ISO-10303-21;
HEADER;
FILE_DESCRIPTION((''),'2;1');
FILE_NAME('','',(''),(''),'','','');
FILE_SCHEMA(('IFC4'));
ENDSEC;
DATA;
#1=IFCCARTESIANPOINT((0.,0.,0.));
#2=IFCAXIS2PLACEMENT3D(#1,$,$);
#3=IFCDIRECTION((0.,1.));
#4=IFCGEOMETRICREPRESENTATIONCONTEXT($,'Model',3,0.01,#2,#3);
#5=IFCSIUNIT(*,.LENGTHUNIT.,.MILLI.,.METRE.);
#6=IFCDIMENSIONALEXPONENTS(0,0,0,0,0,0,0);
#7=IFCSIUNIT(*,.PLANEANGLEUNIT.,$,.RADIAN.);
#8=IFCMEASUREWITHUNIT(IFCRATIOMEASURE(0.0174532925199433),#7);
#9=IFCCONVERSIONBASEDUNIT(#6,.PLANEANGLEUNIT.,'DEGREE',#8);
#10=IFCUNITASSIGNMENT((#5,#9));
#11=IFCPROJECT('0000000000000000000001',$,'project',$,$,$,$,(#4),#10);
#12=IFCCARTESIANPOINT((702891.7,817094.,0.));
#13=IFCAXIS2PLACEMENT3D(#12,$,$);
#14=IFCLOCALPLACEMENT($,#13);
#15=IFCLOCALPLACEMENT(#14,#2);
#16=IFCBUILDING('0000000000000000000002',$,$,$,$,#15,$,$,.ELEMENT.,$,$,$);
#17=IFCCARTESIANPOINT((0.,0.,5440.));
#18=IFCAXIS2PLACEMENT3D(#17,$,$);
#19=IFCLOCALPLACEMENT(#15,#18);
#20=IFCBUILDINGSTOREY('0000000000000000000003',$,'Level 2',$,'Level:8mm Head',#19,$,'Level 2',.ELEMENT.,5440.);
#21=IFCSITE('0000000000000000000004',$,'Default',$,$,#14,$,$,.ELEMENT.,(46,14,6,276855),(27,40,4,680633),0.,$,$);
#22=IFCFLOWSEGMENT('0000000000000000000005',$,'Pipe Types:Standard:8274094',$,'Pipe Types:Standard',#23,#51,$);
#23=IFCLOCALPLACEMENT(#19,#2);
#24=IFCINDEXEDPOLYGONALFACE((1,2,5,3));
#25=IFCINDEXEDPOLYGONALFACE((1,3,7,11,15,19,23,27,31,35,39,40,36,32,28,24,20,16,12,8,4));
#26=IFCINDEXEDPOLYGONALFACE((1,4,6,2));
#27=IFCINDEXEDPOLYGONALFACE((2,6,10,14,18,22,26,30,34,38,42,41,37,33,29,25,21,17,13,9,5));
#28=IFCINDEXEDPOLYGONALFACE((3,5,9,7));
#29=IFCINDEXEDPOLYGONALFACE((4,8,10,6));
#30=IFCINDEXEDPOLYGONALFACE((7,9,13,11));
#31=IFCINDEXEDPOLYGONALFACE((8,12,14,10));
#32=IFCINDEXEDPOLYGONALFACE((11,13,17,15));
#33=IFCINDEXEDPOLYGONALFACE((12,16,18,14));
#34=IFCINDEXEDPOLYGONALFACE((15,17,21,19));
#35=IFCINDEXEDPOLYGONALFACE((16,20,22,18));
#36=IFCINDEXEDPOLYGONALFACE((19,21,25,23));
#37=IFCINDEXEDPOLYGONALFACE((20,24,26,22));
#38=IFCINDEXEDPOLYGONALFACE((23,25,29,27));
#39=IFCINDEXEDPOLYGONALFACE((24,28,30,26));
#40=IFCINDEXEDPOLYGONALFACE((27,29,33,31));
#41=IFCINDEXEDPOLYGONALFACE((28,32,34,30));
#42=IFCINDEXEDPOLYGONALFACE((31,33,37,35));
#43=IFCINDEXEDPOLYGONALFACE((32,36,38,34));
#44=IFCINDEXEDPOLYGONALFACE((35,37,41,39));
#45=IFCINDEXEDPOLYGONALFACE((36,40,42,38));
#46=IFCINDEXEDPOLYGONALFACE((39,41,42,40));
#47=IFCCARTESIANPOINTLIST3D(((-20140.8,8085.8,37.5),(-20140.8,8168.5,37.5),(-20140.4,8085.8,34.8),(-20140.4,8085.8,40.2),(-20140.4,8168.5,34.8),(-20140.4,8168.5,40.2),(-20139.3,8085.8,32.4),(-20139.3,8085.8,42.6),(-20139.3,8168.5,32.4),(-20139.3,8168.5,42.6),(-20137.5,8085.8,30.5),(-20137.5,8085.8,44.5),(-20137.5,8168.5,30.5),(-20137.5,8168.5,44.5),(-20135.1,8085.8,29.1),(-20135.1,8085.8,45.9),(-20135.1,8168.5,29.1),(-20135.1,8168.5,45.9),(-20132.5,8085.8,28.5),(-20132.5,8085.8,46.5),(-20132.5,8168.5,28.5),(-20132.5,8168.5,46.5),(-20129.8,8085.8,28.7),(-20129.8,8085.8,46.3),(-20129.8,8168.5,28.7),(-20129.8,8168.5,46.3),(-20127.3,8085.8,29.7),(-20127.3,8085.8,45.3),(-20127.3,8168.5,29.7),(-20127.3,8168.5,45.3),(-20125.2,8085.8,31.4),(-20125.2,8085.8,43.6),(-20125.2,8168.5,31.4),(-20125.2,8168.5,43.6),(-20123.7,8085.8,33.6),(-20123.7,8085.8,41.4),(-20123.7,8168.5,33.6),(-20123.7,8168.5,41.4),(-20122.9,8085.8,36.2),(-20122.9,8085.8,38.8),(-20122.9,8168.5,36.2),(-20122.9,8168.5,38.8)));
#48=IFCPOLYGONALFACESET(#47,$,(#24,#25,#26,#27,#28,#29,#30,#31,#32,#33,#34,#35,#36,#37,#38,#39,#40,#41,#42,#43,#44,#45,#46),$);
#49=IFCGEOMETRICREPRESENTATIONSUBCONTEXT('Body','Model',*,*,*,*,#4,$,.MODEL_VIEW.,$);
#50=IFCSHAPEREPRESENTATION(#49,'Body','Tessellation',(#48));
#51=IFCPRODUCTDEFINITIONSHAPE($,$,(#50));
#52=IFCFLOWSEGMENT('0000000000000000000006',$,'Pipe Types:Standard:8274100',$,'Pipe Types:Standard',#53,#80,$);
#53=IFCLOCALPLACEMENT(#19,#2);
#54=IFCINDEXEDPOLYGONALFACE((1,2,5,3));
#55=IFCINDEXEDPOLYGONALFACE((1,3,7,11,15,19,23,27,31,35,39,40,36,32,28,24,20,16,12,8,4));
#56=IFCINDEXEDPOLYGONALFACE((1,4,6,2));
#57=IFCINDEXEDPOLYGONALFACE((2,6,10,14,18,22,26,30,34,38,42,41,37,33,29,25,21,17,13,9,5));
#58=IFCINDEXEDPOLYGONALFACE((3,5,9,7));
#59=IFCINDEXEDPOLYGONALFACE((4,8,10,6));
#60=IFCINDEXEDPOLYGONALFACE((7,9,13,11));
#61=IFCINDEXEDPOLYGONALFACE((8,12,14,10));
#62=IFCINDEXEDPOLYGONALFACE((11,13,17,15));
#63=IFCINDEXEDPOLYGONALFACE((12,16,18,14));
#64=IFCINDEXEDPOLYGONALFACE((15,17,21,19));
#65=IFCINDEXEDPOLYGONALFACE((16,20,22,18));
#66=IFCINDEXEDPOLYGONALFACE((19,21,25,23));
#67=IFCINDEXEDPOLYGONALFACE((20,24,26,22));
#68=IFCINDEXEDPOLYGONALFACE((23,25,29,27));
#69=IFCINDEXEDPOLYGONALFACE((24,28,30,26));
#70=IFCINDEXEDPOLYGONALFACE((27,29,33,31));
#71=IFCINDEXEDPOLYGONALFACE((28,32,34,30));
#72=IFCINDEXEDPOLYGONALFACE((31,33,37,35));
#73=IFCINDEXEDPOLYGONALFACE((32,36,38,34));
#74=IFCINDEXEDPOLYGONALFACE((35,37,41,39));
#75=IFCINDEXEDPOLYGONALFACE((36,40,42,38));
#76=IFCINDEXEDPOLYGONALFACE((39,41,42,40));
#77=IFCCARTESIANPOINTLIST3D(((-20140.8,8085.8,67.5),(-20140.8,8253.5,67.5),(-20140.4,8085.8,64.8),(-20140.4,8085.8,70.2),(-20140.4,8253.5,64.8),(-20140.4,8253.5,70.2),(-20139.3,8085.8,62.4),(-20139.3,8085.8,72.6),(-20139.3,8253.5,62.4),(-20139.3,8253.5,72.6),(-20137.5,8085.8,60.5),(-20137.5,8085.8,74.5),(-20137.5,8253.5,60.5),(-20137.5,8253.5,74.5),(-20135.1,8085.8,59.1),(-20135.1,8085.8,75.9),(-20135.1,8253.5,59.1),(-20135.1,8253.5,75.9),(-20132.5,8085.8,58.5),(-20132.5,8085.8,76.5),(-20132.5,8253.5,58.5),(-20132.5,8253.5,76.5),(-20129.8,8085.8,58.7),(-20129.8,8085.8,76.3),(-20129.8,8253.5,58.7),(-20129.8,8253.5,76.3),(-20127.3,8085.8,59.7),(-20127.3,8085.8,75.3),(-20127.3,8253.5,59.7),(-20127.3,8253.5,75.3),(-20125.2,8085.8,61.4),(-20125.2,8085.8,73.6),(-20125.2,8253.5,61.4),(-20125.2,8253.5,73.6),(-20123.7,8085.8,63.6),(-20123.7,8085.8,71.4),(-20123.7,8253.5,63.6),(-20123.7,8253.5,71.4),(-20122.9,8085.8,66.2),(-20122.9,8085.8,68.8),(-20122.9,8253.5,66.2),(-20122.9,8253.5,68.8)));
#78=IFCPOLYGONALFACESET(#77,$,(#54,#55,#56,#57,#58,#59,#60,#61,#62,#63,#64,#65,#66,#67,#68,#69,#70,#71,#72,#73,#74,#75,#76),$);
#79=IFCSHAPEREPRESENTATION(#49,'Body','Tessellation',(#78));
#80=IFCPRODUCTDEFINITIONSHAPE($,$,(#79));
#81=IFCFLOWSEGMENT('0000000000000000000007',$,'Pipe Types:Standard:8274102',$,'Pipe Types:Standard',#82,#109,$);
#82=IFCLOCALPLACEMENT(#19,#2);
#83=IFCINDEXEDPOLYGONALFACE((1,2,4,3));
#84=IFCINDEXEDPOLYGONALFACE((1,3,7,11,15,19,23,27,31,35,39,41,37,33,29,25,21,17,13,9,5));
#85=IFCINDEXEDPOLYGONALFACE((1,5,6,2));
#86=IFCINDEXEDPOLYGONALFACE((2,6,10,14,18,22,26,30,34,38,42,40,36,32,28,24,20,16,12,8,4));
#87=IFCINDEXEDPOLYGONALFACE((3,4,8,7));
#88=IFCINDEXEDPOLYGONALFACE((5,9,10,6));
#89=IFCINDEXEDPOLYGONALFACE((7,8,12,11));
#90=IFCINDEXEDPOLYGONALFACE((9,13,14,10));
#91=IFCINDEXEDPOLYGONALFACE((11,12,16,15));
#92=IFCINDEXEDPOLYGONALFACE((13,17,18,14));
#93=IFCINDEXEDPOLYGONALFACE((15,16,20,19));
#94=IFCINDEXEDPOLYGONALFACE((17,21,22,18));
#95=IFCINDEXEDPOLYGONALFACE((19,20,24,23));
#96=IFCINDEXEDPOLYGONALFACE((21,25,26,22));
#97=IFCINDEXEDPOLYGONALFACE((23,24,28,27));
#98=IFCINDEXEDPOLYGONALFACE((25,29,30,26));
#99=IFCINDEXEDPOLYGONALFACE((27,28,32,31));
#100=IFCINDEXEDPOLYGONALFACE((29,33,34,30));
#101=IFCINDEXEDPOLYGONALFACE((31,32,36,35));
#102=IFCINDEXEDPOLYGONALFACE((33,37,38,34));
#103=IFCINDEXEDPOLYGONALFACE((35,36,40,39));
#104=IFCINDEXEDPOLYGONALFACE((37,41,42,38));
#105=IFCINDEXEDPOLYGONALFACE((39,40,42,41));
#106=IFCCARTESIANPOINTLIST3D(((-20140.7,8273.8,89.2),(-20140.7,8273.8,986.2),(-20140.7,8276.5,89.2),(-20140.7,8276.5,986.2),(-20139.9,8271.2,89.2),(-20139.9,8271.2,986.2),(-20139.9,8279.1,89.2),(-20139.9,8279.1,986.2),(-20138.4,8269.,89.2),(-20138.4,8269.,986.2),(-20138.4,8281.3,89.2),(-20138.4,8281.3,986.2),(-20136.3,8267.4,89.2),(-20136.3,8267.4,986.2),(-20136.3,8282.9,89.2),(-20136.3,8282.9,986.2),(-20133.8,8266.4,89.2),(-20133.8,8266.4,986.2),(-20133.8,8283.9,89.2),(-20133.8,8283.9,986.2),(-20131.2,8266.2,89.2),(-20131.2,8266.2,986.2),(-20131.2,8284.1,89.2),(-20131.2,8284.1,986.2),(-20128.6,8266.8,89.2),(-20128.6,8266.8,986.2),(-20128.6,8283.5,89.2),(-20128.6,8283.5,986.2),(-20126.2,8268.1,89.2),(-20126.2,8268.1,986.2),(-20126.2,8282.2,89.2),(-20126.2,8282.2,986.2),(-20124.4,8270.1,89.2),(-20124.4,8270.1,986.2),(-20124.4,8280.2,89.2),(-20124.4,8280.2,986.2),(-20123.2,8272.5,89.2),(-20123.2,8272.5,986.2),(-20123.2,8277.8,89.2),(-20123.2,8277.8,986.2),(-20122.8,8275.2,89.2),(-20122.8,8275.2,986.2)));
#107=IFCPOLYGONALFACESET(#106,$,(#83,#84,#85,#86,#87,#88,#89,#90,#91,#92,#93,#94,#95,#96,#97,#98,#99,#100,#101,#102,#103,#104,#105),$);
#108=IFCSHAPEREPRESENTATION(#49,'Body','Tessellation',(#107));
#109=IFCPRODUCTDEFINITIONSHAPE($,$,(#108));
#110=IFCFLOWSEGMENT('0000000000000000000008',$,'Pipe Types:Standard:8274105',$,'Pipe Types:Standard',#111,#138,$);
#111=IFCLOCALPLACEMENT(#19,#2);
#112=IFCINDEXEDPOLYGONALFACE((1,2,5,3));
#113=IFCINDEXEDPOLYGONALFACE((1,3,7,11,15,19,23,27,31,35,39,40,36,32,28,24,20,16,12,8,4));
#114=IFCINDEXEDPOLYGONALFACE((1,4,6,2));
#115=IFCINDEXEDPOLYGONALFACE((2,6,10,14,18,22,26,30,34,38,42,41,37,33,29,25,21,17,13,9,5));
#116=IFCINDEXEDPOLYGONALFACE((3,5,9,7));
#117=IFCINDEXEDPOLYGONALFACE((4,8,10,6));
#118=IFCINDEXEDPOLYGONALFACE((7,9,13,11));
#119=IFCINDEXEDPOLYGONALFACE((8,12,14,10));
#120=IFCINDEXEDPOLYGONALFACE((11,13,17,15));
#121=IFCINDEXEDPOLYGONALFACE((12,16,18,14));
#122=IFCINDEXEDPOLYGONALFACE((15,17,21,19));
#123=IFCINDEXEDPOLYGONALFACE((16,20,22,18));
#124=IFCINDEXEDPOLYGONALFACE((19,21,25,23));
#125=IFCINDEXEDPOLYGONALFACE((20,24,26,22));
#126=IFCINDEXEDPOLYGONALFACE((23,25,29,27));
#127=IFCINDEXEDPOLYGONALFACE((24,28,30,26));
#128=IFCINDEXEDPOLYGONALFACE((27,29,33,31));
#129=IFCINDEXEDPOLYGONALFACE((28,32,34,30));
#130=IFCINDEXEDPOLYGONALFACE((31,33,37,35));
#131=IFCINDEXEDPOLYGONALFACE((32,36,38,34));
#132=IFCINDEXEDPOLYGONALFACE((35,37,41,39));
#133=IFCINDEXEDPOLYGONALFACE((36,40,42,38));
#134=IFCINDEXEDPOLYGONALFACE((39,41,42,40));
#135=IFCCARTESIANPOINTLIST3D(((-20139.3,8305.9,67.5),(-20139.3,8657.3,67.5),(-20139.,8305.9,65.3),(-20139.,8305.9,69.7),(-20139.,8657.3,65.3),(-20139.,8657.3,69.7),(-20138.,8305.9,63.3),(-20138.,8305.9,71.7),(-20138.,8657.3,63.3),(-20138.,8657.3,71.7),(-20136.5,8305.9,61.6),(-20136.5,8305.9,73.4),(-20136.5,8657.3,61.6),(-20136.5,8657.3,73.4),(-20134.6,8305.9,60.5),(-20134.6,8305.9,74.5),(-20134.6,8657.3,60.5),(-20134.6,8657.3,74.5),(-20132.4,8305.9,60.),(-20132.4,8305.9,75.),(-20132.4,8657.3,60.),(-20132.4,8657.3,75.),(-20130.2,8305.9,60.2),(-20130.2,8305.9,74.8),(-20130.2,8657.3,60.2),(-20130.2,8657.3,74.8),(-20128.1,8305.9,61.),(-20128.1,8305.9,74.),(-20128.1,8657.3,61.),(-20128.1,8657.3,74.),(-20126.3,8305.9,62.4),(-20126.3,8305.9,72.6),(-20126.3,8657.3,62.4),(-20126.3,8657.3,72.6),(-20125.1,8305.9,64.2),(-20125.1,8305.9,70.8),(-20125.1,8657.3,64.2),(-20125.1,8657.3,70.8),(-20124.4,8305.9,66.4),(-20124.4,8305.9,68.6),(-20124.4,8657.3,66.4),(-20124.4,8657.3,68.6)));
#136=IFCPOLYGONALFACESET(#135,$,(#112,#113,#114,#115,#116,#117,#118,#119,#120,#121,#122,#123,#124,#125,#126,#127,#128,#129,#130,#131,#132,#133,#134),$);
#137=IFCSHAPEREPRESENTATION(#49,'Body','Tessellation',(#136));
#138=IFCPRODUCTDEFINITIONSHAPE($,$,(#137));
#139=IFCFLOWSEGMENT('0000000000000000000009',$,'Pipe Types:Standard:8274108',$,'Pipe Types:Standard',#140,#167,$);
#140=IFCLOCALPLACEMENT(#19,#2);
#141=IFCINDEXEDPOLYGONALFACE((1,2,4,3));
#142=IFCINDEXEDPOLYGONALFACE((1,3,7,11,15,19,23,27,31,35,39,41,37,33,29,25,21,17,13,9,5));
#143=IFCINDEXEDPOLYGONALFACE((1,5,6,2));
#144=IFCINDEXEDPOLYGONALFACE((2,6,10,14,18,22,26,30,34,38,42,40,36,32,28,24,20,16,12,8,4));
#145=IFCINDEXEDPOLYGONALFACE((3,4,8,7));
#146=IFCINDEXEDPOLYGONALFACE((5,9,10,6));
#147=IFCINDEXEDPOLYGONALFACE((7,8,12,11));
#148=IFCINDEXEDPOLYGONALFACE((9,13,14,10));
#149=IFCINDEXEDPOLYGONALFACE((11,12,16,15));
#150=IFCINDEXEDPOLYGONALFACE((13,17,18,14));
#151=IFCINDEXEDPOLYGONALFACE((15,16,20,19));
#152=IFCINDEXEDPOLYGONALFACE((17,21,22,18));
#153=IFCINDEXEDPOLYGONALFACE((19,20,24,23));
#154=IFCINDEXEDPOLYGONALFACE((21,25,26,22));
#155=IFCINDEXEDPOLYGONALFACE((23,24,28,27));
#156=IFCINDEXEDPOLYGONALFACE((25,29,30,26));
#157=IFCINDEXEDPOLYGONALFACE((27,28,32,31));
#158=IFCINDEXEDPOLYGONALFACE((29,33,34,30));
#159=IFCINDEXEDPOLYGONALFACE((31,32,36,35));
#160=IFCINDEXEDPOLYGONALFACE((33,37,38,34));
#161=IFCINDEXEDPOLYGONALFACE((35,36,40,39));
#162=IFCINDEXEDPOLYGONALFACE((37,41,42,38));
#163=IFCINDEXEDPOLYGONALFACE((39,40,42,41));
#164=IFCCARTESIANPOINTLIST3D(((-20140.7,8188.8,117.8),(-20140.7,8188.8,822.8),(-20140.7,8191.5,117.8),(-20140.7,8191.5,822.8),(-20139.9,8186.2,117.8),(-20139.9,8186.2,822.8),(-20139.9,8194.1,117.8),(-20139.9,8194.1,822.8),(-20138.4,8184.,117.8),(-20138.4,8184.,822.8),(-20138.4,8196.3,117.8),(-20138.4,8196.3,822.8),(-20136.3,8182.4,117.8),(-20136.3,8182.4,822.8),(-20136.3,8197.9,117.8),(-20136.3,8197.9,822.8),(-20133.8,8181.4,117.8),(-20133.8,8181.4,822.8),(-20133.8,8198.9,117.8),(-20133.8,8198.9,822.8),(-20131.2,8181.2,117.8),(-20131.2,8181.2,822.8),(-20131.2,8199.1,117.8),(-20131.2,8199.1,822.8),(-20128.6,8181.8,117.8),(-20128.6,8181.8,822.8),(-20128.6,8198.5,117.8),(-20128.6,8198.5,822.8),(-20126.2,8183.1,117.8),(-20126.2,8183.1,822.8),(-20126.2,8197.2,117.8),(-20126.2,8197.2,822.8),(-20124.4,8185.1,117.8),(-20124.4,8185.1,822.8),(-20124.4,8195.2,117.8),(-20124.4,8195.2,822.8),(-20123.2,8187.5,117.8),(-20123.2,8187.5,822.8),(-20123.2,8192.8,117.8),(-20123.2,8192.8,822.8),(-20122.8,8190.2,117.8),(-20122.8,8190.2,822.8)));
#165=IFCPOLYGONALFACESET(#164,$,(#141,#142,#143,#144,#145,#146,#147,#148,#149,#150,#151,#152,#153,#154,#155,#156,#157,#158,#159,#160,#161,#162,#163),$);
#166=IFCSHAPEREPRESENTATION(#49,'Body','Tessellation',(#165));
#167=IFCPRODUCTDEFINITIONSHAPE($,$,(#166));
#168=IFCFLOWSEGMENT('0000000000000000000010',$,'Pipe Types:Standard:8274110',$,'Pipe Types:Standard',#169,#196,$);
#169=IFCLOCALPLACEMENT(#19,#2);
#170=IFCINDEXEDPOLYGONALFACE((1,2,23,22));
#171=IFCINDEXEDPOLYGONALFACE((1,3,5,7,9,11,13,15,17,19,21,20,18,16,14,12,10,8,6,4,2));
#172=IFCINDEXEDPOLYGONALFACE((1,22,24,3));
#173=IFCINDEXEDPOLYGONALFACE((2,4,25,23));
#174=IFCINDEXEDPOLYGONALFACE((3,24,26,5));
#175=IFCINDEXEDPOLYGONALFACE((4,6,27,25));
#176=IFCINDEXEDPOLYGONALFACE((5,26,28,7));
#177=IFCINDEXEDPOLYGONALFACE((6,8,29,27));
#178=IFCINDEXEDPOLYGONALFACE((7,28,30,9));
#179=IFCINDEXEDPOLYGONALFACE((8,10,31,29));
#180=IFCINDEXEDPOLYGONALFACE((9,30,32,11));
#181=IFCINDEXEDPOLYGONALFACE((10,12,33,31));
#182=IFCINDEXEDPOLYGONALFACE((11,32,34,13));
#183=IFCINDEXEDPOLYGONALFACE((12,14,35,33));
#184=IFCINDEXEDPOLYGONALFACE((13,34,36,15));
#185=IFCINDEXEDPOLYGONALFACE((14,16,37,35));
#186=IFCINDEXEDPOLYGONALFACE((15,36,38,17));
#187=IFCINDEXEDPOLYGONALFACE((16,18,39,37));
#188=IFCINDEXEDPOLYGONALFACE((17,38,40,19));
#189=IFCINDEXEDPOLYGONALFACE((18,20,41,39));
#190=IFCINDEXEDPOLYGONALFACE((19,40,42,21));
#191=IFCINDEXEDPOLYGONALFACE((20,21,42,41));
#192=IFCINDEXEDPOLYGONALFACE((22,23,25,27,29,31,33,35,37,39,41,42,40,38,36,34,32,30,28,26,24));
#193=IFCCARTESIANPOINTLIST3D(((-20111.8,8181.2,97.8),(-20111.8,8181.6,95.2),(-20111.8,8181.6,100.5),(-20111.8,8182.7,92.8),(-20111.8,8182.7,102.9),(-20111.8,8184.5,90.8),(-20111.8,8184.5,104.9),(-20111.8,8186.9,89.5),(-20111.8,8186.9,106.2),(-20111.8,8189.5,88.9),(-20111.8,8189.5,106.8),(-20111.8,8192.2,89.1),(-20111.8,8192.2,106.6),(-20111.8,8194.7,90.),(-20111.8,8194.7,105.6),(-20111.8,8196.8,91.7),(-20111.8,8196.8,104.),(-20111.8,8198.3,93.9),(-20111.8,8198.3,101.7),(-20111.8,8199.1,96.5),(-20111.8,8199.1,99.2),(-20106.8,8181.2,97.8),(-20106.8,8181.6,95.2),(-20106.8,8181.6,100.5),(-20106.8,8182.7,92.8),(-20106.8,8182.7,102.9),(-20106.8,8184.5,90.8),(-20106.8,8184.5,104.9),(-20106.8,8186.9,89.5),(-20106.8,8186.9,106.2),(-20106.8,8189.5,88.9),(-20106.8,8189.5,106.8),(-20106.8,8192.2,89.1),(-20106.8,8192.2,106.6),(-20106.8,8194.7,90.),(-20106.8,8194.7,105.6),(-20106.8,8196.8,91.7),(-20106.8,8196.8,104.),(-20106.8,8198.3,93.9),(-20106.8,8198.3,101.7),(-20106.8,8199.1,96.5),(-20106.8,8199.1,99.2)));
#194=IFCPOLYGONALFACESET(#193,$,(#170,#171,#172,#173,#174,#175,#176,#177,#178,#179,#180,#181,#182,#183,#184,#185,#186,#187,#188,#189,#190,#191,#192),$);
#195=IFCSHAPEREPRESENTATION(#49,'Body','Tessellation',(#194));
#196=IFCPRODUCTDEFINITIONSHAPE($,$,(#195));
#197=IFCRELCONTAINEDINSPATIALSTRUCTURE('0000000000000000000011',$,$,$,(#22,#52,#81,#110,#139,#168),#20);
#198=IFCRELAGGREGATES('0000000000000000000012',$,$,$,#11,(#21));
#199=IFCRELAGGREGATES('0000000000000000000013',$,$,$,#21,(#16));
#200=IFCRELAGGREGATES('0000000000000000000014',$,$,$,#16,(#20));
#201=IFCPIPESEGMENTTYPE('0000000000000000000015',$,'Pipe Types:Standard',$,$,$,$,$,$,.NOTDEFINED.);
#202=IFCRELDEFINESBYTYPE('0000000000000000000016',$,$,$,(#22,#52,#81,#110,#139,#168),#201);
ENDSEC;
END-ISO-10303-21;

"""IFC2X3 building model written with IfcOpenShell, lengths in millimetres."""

from ifc_helpers import new_model, entity, si_unit, converted_unit, direction, frame, frame_2d, origin, origin_2d_with_axis, place, context, subcontext, project, spatial, circle, extrude, type_object, element, save


model = new_model("IFC2X3")

# Units and contexts
model_context = context("Model", 3, precision=0.01, world=origin(), true_north=direction((0.0, 1.0)))
body_context = subcontext(model_context, "Body", "Model", "MODEL_VIEW")
ifc_project = project(units=[si_unit("LENGTHUNIT", "METRE", prefix="MILLI"), converted_unit("PLANEANGLEUNIT", "DEGREE", entity("IfcRatioMeasure", 0.0174532925199433), si_unit("PLANEANGLEUNIT", "RADIAN"), dimensions=[0, 0, 0, 0, 0, 0, 0])], contexts=[model_context])

# Site, building, storey
site_placement = place(None, frame((702891.7, 817094.0, 0.0)))
site = spatial("IfcSite", under=ifc_project, at=site_placement, Name="Default", CompositionType="ELEMENT", RefLatitude=(46, 14, 6, 276855), RefLongitude=(27, 40, 4, 680633), RefElevation=0.0)
building_placement = place(site_placement, origin())
building = spatial("IfcBuilding", under=site, at=building_placement, CompositionType="ELEMENT")
storey_placement = place(building_placement, frame((0.0, 0.0, 5440.0)))
storey = spatial("IfcBuildingStorey", under=building, at=storey_placement, Name="Level 2", ObjectType="Level:8mm Head", LongName="Level 2", CompositionType="ELEMENT", Elevation=5440.0)

# Flow segments
pipe_segment_type = type_object("IfcPipeSegmentType", Name="Pipe Types:Standard", PredefinedType="NOTDEFINED")
flow_segment_1_placement = place(storey_placement, origin())
element("IfcFlowSegment", 1, at=flow_segment_1_placement, inside=storey, type_object=pipe_segment_type, Name="Pipe Types:Standard:8274094", ObjectType="Pipe Types:Standard", context=body_context, shape_type="SweptSolid", body=[
    extrude(circle(Radius=9.0, at=origin_2d_with_axis()), frame((-20131.8, 8085.8, 37.5), z_axis=(0.0, 1.0, 0.0), x_axis=(-1.0, 0.0, 0.0)), (0.0, 0.0, 1.0), 82.6),
])
flow_segment_2_placement = place(storey_placement, origin())
element("IfcFlowSegment", 2, at=flow_segment_2_placement, inside=storey, type_object=pipe_segment_type, Name="Pipe Types:Standard:8274100", ObjectType="Pipe Types:Standard", context=body_context, shape_type="SweptSolid", body=[
    extrude(circle(Radius=9.0, at=origin_2d_with_axis()), frame((-20131.8, 8085.8, 67.5), z_axis=(0.0, 1.0, 0.0), x_axis=(-1.0, 0.0, 0.0)), (0.0, 0.0, 1.0), 167.6),
])
flow_segment_3_placement = place(storey_placement, origin())
element("IfcFlowSegment", 3, at=flow_segment_3_placement, inside=storey, type_object=pipe_segment_type, Name="Pipe Types:Standard:8274102", ObjectType="Pipe Types:Standard", context=body_context, shape_type="SweptSolid", body=[
    extrude(circle(Radius=9.0, at=origin_2d_with_axis()), frame((-20131.8, 8275.2, 89.2)), (0.0, 0.0, 1.0), 897.0),
])
flow_segment_4_placement = place(storey_placement, origin())
element("IfcFlowSegment", 4, at=flow_segment_4_placement, inside=storey, type_object=pipe_segment_type, Name="Pipe Types:Standard:8274105", ObjectType="Pipe Types:Standard", context=body_context, shape_type="SweptSolid", body=[
    extrude(circle(Radius=7.5, at=frame_2d((0.0, 0.0), x_axis=(1.0, 0.0))), frame((-20131.8, 8305.9, 67.5), z_axis=(0.0, 1.0, 0.0), x_axis=(-1.0, 0.0, 0.0)), (0.0, 0.0, 1.0), 351.5),
])
flow_segment_5_placement = place(storey_placement, origin())
element("IfcFlowSegment", 5, at=flow_segment_5_placement, inside=storey, type_object=pipe_segment_type, Name="Pipe Types:Standard:8274108", ObjectType="Pipe Types:Standard", context=body_context, shape_type="SweptSolid", body=[
    extrude(circle(Radius=9.0, at=origin_2d_with_axis()), frame((-20131.8, 8190.2, 117.8)), (0.0, 0.0, 1.0), 705.0),
])
flow_segment_6_placement = place(storey_placement, origin())
element("IfcFlowSegment", 6, at=flow_segment_6_placement, inside=storey, type_object=pipe_segment_type, Name="Pipe Types:Standard:8274110", ObjectType="Pipe Types:Standard", context=body_context, shape_type="SweptSolid", body=[
    extrude(circle(Radius=9.0, at=origin_2d_with_axis()), frame((-20111.8, 8190.2, 97.8), z_axis=(1.0, 0.0, 0.0), x_axis=(0.0, -1.0, 0.0)), (0.0, 0.0, 1.0), 5.0),
])

save(model, "model.ifc")
